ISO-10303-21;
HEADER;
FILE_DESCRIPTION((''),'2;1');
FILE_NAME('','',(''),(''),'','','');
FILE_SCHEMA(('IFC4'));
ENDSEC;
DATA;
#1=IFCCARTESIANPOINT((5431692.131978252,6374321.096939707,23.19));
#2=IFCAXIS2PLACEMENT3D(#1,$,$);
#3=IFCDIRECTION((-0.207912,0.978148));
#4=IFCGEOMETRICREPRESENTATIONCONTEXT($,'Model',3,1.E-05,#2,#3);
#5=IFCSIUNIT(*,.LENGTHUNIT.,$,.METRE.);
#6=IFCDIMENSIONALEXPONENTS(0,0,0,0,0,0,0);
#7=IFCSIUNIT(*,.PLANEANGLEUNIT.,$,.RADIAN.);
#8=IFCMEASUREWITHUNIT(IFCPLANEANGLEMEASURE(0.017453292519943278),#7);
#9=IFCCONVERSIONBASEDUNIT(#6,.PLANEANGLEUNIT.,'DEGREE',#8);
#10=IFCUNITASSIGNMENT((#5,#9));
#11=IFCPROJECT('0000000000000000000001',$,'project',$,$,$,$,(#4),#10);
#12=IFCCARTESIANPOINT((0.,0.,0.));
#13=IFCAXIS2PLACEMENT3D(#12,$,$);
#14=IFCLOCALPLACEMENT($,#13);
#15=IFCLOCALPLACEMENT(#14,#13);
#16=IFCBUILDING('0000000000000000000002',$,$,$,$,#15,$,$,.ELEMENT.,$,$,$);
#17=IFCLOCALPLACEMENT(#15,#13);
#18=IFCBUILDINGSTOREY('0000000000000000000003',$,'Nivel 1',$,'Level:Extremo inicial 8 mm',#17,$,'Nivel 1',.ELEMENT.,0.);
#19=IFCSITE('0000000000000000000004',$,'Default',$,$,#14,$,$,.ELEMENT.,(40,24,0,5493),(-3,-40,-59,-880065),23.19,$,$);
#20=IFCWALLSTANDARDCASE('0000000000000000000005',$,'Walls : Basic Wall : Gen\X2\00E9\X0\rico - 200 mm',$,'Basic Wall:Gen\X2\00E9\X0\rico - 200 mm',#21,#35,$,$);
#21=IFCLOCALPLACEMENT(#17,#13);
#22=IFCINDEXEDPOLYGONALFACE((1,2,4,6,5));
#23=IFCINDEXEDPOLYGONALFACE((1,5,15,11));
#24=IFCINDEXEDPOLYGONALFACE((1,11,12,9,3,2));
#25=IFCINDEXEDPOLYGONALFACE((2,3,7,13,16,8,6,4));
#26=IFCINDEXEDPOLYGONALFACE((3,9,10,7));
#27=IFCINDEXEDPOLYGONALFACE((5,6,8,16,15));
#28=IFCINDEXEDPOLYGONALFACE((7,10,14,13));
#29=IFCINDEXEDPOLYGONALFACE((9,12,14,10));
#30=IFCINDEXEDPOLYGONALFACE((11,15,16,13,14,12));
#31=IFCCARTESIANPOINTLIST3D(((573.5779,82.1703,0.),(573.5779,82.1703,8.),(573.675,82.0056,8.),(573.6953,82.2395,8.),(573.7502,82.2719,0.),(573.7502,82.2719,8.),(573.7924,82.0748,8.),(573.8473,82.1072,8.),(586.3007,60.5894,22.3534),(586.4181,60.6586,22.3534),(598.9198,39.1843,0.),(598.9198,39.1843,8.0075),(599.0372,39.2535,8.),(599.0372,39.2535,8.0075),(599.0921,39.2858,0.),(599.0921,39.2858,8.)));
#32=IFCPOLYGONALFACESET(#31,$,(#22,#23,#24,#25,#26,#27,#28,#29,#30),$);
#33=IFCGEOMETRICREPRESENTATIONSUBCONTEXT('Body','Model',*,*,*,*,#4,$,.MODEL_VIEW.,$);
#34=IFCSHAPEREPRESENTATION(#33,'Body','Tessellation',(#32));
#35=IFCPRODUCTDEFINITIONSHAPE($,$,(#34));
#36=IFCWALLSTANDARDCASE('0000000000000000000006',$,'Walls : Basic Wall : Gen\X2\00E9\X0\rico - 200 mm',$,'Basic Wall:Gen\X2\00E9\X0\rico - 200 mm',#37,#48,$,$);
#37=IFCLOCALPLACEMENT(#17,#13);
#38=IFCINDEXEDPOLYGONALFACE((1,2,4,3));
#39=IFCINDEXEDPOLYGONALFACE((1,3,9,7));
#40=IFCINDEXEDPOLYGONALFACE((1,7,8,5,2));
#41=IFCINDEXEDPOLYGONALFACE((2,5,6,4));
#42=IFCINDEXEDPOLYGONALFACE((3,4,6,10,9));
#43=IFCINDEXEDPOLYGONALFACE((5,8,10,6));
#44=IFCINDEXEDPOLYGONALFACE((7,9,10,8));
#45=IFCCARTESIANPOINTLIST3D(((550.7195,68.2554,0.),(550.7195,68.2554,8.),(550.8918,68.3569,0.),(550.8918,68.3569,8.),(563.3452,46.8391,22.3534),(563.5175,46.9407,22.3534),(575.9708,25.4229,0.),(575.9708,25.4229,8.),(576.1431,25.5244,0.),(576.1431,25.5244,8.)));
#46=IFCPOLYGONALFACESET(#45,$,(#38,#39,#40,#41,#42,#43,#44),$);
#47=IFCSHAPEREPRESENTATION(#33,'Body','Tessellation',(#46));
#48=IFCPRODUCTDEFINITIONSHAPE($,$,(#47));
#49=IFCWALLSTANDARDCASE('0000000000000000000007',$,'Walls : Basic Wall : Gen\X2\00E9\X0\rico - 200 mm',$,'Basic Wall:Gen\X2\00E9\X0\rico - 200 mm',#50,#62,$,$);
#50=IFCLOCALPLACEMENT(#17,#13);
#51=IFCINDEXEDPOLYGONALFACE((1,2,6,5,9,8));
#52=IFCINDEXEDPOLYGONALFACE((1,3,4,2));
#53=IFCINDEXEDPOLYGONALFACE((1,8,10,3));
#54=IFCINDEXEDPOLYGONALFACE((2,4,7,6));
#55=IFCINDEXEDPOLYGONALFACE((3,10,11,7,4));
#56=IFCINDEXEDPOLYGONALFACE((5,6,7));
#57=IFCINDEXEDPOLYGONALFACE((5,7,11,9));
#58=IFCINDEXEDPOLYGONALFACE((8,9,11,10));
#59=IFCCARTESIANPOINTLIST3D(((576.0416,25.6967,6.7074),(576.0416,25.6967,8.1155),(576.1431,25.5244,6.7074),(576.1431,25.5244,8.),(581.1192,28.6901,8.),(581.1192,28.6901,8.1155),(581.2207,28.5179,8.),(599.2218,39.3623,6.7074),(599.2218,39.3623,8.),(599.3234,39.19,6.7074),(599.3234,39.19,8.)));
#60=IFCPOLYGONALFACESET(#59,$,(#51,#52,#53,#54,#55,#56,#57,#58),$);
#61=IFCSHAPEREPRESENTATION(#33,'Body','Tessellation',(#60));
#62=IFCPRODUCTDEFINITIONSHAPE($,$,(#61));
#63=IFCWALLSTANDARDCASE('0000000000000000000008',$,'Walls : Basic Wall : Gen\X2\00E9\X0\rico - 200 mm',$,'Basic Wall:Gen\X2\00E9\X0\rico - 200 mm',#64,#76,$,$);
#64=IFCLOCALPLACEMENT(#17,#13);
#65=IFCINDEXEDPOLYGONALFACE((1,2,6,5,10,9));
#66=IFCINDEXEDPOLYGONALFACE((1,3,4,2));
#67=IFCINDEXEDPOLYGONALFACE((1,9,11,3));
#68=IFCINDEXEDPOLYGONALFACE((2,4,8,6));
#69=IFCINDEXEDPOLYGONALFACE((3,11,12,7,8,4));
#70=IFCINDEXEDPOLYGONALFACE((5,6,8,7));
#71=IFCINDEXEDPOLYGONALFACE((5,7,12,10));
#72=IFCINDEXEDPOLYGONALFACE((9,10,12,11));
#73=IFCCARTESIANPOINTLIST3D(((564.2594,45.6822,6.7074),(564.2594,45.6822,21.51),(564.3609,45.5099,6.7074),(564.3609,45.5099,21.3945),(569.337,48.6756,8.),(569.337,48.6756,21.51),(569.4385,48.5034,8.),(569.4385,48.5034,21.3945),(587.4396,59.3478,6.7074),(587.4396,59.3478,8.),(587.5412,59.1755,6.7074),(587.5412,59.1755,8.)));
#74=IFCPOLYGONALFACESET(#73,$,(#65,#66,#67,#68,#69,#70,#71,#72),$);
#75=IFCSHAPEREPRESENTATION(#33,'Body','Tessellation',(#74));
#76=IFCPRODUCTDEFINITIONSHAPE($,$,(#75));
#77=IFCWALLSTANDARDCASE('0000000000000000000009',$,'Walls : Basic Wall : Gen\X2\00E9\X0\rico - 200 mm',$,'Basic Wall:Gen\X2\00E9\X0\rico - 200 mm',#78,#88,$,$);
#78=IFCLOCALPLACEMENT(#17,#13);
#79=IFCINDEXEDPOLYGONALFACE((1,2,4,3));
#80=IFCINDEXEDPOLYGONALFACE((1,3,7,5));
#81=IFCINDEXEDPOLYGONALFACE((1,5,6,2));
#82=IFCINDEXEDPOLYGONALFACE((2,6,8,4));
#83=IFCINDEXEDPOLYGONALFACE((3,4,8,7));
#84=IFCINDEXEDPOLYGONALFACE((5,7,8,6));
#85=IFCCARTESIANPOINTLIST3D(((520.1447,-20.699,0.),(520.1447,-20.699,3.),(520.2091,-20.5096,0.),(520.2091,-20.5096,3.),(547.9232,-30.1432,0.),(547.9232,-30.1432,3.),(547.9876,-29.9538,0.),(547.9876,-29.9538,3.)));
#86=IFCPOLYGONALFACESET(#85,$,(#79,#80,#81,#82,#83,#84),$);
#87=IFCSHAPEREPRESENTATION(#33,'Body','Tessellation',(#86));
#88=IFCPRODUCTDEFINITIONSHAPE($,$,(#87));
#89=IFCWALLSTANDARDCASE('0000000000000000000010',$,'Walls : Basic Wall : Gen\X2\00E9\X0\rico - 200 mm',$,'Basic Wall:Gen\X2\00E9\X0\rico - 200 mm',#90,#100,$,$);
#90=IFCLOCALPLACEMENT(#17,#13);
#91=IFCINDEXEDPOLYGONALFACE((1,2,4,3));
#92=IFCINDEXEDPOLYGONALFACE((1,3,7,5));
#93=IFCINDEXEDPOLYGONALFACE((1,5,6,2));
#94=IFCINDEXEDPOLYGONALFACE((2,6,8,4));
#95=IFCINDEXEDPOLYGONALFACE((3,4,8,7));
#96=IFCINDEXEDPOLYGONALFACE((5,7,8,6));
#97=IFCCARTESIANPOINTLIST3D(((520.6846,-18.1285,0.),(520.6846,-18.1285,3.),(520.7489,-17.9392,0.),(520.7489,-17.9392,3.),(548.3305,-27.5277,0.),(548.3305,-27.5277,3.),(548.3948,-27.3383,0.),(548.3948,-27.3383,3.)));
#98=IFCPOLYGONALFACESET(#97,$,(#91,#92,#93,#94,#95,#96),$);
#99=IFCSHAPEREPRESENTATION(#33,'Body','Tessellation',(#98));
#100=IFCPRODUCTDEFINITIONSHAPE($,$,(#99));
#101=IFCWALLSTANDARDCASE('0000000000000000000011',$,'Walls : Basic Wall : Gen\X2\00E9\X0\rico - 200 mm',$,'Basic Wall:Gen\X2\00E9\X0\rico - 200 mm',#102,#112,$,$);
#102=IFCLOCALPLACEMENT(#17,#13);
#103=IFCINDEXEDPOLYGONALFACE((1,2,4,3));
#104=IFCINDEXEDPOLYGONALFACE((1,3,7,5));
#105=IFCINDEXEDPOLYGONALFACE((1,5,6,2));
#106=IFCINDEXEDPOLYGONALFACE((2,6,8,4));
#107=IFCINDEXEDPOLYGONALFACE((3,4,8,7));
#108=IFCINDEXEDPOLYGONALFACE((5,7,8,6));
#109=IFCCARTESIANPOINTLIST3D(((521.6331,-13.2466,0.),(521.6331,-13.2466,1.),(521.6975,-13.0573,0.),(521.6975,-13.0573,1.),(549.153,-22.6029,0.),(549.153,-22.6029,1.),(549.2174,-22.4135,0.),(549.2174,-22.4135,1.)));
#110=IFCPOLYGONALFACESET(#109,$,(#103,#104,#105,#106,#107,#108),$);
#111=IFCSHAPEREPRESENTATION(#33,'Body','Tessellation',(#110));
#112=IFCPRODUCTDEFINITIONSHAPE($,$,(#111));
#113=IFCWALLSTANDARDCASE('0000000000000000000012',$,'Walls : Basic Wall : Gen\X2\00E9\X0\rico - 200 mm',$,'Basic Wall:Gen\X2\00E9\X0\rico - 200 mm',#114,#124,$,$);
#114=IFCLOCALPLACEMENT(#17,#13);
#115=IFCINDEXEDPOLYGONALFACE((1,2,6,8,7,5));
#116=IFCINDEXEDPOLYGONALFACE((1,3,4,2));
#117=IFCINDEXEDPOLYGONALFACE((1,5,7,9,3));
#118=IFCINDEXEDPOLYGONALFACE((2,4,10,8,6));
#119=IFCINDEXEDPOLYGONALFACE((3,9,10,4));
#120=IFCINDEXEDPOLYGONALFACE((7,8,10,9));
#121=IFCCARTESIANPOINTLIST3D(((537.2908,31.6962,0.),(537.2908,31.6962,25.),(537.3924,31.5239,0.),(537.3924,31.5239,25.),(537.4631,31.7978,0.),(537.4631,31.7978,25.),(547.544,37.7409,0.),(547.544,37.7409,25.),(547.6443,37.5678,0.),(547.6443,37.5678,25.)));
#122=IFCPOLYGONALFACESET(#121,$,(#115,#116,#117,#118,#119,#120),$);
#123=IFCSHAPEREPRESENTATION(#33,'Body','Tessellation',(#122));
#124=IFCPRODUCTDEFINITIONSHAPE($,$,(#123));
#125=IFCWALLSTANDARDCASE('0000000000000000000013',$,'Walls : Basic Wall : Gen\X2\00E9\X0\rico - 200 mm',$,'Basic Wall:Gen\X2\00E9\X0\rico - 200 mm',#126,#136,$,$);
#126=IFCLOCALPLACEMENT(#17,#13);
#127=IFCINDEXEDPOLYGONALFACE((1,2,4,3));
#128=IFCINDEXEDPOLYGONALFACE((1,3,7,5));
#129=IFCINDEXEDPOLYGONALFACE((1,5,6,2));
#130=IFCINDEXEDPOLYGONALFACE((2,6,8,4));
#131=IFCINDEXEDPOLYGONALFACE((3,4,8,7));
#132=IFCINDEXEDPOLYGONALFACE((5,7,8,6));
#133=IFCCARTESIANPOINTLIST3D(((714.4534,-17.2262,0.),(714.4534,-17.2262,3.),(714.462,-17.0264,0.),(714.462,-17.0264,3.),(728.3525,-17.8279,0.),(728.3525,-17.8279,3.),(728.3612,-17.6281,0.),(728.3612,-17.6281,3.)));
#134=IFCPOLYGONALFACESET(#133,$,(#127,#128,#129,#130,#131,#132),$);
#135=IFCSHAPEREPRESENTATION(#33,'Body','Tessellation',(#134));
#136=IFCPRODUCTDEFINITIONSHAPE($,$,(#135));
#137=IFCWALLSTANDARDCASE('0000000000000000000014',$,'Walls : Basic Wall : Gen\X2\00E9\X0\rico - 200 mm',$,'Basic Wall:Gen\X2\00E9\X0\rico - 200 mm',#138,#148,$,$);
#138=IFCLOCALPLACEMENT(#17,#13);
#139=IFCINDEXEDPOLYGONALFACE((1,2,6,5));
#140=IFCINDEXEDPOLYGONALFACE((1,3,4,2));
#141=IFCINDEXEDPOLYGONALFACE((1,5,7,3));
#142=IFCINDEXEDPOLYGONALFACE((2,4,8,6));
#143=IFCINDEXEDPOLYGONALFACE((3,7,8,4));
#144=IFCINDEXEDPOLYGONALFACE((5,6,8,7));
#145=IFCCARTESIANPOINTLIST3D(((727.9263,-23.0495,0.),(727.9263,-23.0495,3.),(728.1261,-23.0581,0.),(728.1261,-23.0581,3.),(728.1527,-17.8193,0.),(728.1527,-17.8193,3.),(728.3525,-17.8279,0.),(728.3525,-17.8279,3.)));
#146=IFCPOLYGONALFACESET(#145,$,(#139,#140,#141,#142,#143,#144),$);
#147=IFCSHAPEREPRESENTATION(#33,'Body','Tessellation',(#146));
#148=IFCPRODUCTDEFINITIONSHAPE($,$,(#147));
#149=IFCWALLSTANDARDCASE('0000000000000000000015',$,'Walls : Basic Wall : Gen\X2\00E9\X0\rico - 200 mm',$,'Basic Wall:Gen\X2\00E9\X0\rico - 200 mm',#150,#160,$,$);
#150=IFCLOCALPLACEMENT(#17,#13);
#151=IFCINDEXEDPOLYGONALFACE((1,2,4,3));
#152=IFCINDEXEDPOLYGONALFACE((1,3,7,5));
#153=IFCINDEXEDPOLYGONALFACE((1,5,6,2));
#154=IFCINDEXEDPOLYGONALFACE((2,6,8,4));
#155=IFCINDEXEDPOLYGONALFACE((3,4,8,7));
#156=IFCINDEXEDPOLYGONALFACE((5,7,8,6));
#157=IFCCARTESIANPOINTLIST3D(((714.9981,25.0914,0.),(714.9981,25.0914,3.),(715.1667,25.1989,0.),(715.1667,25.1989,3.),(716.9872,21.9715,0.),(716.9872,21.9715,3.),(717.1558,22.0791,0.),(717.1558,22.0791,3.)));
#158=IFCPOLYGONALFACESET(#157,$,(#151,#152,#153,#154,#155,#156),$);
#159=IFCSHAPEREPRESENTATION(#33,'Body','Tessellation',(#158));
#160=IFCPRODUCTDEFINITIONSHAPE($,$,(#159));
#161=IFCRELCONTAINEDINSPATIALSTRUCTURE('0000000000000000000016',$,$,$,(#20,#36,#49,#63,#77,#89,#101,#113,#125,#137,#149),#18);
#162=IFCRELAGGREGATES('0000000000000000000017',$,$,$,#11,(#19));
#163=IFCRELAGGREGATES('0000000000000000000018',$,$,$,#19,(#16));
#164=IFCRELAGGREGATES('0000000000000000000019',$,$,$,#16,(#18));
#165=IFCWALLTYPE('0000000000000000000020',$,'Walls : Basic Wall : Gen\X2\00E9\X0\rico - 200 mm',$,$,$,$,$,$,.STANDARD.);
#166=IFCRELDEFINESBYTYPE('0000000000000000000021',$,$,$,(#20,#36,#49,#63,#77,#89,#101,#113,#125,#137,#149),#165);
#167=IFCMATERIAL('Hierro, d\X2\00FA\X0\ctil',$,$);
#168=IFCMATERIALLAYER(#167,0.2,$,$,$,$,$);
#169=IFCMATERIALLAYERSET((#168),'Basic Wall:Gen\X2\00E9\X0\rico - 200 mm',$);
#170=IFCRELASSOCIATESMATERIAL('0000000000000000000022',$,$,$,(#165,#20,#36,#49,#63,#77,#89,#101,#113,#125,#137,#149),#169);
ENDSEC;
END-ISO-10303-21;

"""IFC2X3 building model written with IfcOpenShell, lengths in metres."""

from ifc_helpers import new_model, entity, si_unit, converted_unit, direction, frame, frame_2d, origin, place, context, subcontext, project, spatial, polyline, rectangle, outline, extrude, clip, bounded_halfspace, material, layer, layer_set, layer_usage, type_object, element, save


model = new_model("IFC2X3")

# Units and contexts
model_context = context("Model", 3, precision=1e-05, world=frame((5431692.131978252, 6374321.096939707, 23.19)), true_north=direction((-0.207912, 0.978148)))
body_context = subcontext(model_context, "Body", "Model", "MODEL_VIEW")
ifc_project = project(units=[si_unit("LENGTHUNIT", "METRE"), converted_unit("PLANEANGLEUNIT", "DEGREE", entity("IfcPlaneAngleMeasure", 0.017453292519943278), si_unit("PLANEANGLEUNIT", "RADIAN"), dimensions=[0, 0, 0, 0, 0, 0, 0])], contexts=[model_context])

# Site, building, storey
site_placement = place(None, origin())
site = spatial("IfcSite", under=ifc_project, at=site_placement, Name="Default", CompositionType="ELEMENT", RefLatitude=(40, 24, 0, 5493), RefLongitude=(-3, -40, -59, -880065), RefElevation=23.19)
building_placement = place(site_placement, origin())
building = spatial("IfcBuilding", under=site, at=building_placement, CompositionType="ELEMENT")
storey_placement = place(building_placement, origin())
storey = spatial("IfcBuildingStorey", under=building, at=storey_placement, Name="Nivel 1", ObjectType="Level:Extremo inicial 8 mm", LongName="Nivel 1", CompositionType="ELEMENT", Elevation=0.0)

# Walls
ifc_material_1 = material(Name="Hierro, dúctil")
ifc_layer_1 = layer(ifc_material_1, 0.2)
ifc_layer_set_1 = layer_set([ifc_layer_1], Name="Basic Wall:Genérico - 200 mm")
wall_type = type_object("IfcWallType", Name="Walls : Basic Wall : Genérico - 200 mm", PredefinedType="STANDARD", material=ifc_layer_set_1)
ifc_layer_usage_1 = layer_usage(ifc_layer_set_1, "AXIS2", "NEGATIVE", 0.1)
wall_1_placement = place(storey_placement, frame((573.6641, 82.2211, 0.0), z_axis=(0.0, 0.0, 1.0), x_axis=(0.507853, -0.861444, 0.0)))
element("IfcWallStandardCase", 1, at=wall_1_placement, inside=storey, type_object=wall_type, material=ifc_layer_usage_1, Name="Walls : Basic Wall : Genérico - 200 mm", ObjectType="Basic Wall:Genérico - 200 mm", context=body_context, shape_type="Clipping", body=[
    clip(clip(clip(clip(clip(extrude(rectangle(XDim=49.9, YDim=0.2, at=frame_2d((24.95, 0.0), x_axis=(-1.0, 0.0))), origin(), (0.0, 0.0, 1.0), 22.3534), bounded_halfspace(frame((0.1912, -0.1, 8.0), z_axis=(-0.5, 0.0, 0.866025), x_axis=(0.0, -1.0, 0.0)), False, frame((0.1912, -0.1, 8.0)), polyline([(0.0, 0.0), (24.8609, 0.0), (24.8609, 0.1363), (0.0, 0.1363), (0.0, 0.0)]))), bounded_halfspace(frame((25.052, -0.1, 22.3534), z_axis=(0.5, 0.0, 0.866025), x_axis=(0.0, 1.0, 0.0)), False, frame((25.052, -0.1, 22.3534)), polyline([(0.0, 0.0), (24.848, 0.0), (24.848, 0.1363), (0.0, 0.1363), (0.0, 0.0)]))), bounded_halfspace(frame((49.9, 0.0363, 8.0), z_axis=(0.0, 0.0, 1.0), x_axis=(0.0, 1.0, 0.0)), False, frame((49.9, 0.0363, 8.0)), polyline([(0.0, 0.0), (0.0, 0.0637), (-49.7088, 0.0637), (-49.7088, 0.0), (0.0, 0.0)]))), bounded_halfspace(frame((0.0, -0.1, 8.0), z_axis=(0.0, 0.0, 1.0), x_axis=(0.0, 1.0, 0.0)), False, frame((0.0, -0.1, 8.0)), polyline([(0.0, 0.0), (0.1912, 0.0), (0.1912, 0.1363), (0.0, 0.1363), (0.0, 0.0)]))), bounded_halfspace(frame((0.1912, 0.0363, 8.0), z_axis=(0.0, 0.0, 1.0), x_axis=(0.0, 1.0, 0.0)), False, frame((0.1912, 0.0363, 8.0)), polyline([(0.0, 0.0), (0.0, 0.0637), (-0.1912, 0.0637), (-0.1912, 0.0), (0.0, 0.0)]))),
])
ifc_layer_usage_2 = layer_usage(ifc_layer_set_1, "AXIS2", "NEGATIVE", 0.1)
wall_2_placement = place(storey_placement, frame((550.8057, 68.3061, 0.0), z_axis=(0.0, 0.0, 1.0), x_axis=(0.507853, -0.861444, 0.0)))
element("IfcWallStandardCase", 2, at=wall_2_placement, inside=storey, type_object=wall_type, material=ifc_layer_usage_2, Name="Walls : Basic Wall : Genérico - 200 mm", ObjectType="Basic Wall:Genérico - 200 mm", context=body_context, shape_type="Clipping", body=[
    clip(clip(extrude(rectangle(XDim=49.7218, YDim=0.2, at=frame_2d((24.8609, 0.0), x_axis=(-1.0, 0.0))), origin(), (0.0, 0.0, 1.0), 22.3534), bounded_halfspace(frame((0.0, -0.1, 8.0), z_axis=(-0.5, 0.0, 0.866025), x_axis=(0.0, -1.0, 0.0)), False, frame((0.0, -0.1, 8.0)), polyline([(0.0, 0.0), (24.8609, 0.0), (24.8609, 0.2), (0.2, 0.2), (0.0, 0.2), (0.0, 0.0)]))), bounded_halfspace(frame((24.8609, -0.1, 22.3534), z_axis=(0.5, 0.0, 0.866025), x_axis=(0.0, 1.0, 0.0)), False, frame((24.8609, -0.1, 22.3534)), polyline([(0.0, 0.0), (24.8609, 0.0), (24.8609, 0.2), (24.6609, 0.2), (1.6609, 0.2), (1.4609, 0.2), (0.0, 0.2), (0.0, 0.0)]))),
])
ifc_layer_usage_3 = layer_usage(ifc_layer_set_1, "AXIS2", "NEGATIVE", 0.1)
wall_3_placement = place(storey_placement, frame((576.0924, 25.6106, 6.7074), z_axis=(0.0, 0.0, 1.0), x_axis=(0.861444, 0.507853, 0.0)))
element("IfcWallStandardCase", 3, at=wall_3_placement, inside=storey, type_object=wall_type, material=ifc_layer_usage_3, Name="Walls : Basic Wall : Genérico - 200 mm", ObjectType="Basic Wall:Genérico - 200 mm", context=body_context, shape_type="Clipping", body=[
    clip(clip(extrude(rectangle(XDim=26.9086, YDim=0.2, at=frame_2d((13.4543, 0.0), x_axis=(-1.0, 0.0))), origin(), (0.0, 0.0, 1.0), 1.408), bounded_halfspace(frame((0.0, -0.1, 1.2926), z_axis=(0.0, -0.5, 0.866025), x_axis=(1.0, 0.0, 0.0)), False, frame((0.0, -0.1, 1.2926)), polyline([(0.0, 0.0), (5.8943, 0.0), (5.8943, 0.2), (0.0, 0.2), (0.0, 0.0)]))), bounded_halfspace(frame((5.8943, -0.1, 1.2926), z_axis=(0.0, 0.0, 1.0), x_axis=(0.0, 1.0, 0.0)), False, frame((5.8943, -0.1, 1.2926)), polyline([(0.0, 0.0), (21.0143, 0.0), (21.0143, 0.2), (20.8637, 0.2), (20.8, 0.2), (0.0, 0.2), (0.0, 0.0)]))),
])
ifc_layer_usage_4 = layer_usage(ifc_layer_set_1, "AXIS2", "NEGATIVE", 0.1)
wall_4_placement = place(storey_placement, frame((564.3102, 45.5961, 6.7074), z_axis=(0.0, 0.0, 1.0), x_axis=(0.861444, 0.507853, 0.0)))
element("IfcWallStandardCase", 4, at=wall_4_placement, inside=storey, type_object=wall_type, material=ifc_layer_usage_4, Name="Walls : Basic Wall : Genérico - 200 mm", ObjectType="Basic Wall:Genérico - 200 mm", context=body_context, shape_type="Clipping", body=[
    clip(clip(extrude(rectangle(XDim=26.9086, YDim=0.2, at=frame_2d((13.4543, 0.0), x_axis=(-1.0, 0.0))), origin(), (0.0, 0.0, 1.0), 14.8026), bounded_halfspace(frame((0.0, -0.1, 14.6871), z_axis=(0.0, -0.5, 0.866025), x_axis=(1.0, 0.0, 0.0)), False, frame((0.0, -0.1, 14.6871)), polyline([(0.0, 0.0), (5.8943, 0.0), (5.8943, 0.2), (0.0, 0.2), (0.0, 0.0)]))), bounded_halfspace(frame((5.8943, -0.1, 1.2926), z_axis=(0.0, 0.0, 1.0), x_axis=(0.0, 1.0, 0.0)), False, frame((5.8943, -0.1, 1.2926)), polyline([(0.0, 0.0), (21.0143, 0.0), (21.0143, 0.2), (0.0, 0.2), (0.0, 0.0)]))),
])
ifc_layer_usage_5 = layer_usage(ifc_layer_set_1, "AXIS2", "NEGATIVE", 0.1)
wall_5_placement = place(storey_placement, frame((547.9554, -30.0485, 0.0), z_axis=(0.0, 0.0, 1.0), x_axis=(-0.946778, 0.321888, 0.0)))
element("IfcWallStandardCase", 5, at=wall_5_placement, inside=storey, type_object=wall_type, material=ifc_layer_usage_5, Name="Walls : Basic Wall : Genérico - 200 mm", ObjectType="Basic Wall:Genérico - 200 mm", context=body_context, shape_type="SweptSolid", body=[
    extrude(rectangle(XDim=29.34, YDim=0.2, at=frame_2d((14.67, 0.0), x_axis=(-1.0, 0.0))), origin(), (0.0, 0.0, 1.0), 3.0),
])
ifc_layer_usage_6 = layer_usage(ifc_layer_set_1, "AXIS2", "NEGATIVE", 0.1)
wall_6_placement = place(storey_placement, frame((548.3627, -27.433, 0.0), z_axis=(0.0, 0.0, 1.0), x_axis=(-0.946778, 0.321888, 0.0)))
element("IfcWallStandardCase", 6, at=wall_6_placement, inside=storey, type_object=wall_type, material=ifc_layer_usage_6, Name="Walls : Basic Wall : Genérico - 200 mm", ObjectType="Basic Wall:Genérico - 200 mm", context=body_context, shape_type="SweptSolid", body=[
    extrude(rectangle(XDim=29.2, YDim=0.2, at=frame_2d((14.6, 0.0), x_axis=(-1.0, 0.0))), origin(), (0.0, 0.0, 1.0), 3.0),
])
ifc_layer_usage_7 = layer_usage(ifc_layer_set_1, "AXIS2", "NEGATIVE", 0.1)
wall_7_placement = place(storey_placement, frame((549.1852, -22.5082, 0.0), z_axis=(0.0, 0.0, 1.0), x_axis=(-0.946778, 0.321888, 0.0)))
element("IfcWallStandardCase", 7, at=wall_7_placement, inside=storey, type_object=wall_type, material=ifc_layer_usage_7, Name="Walls : Basic Wall : Genérico - 200 mm", ObjectType="Basic Wall:Genérico - 200 mm", context=body_context, shape_type="SweptSolid", body=[
    extrude(rectangle(XDim=29.0668, YDim=0.2, at=frame_2d((14.5334, 0.0), x_axis=(-1.0, 0.0))), origin(), (0.0, 0.0, 1.0), 1.0),
])
ifc_layer_usage_8 = layer_usage(ifc_layer_set_1, "AXIS2", "NEGATIVE", 0.1)
wall_8_placement = place(storey_placement, frame((547.5948, 37.6547, 0.0), z_axis=(0.0, 0.0, 1.0), x_axis=(-0.861444, -0.507853, 0.0)))
element("IfcWallStandardCase", 8, at=wall_8_placement, inside=storey, type_object=wall_type, material=ifc_layer_usage_8, Name="Walls : Basic Wall : Genérico - 200 mm", ObjectType="Basic Wall:Genérico - 200 mm", context=body_context, shape_type="SweptSolid", body=[
    extrude(outline(polyline([(11.9024, -0.1), (11.9024, 0.1), (0.0015, 0.1), (0.0, -0.1), (11.7024, -0.1), (11.9024, -0.1)])), origin(), (0.0, 0.0, 1.0), 25.0),
])
ifc_layer_usage_9 = layer_usage(ifc_layer_set_1, "AXIS2", "NEGATIVE", 0.1)
wall_9_placement = place(storey_placement, frame((714.4577, -17.1263, 0.0), z_axis=(0.0, 0.0, 1.0), x_axis=(0.999064, -0.043255, 0.0)))
element("IfcWallStandardCase", 9, at=wall_9_placement, inside=storey, type_object=wall_type, material=ifc_layer_usage_9, Name="Walls : Basic Wall : Genérico - 200 mm", ObjectType="Basic Wall:Genérico - 200 mm", context=body_context, shape_type="SweptSolid", body=[
    extrude(rectangle(XDim=13.9122, YDim=0.2, at=frame_2d((6.9561, 0.0), x_axis=(-1.0, 0.0))), origin(), (0.0, 0.0, 1.0), 3.0),
])
ifc_layer_usage_10 = layer_usage(ifc_layer_set_1, "AXIS2", "NEGATIVE", 0.1)
wall_10_placement = place(storey_placement, frame((728.2526, -17.8236, 0.0), z_axis=(0.0, 0.0, 1.0), x_axis=(-0.043255, -0.999064, 0.0)))
element("IfcWallStandardCase", 10, at=wall_10_placement, inside=storey, type_object=wall_type, material=ifc_layer_usage_10, Name="Walls : Basic Wall : Genérico - 200 mm", ObjectType="Basic Wall:Genérico - 200 mm", context=body_context, shape_type="SweptSolid", body=[
    extrude(rectangle(XDim=5.2351, YDim=0.2, at=frame_2d((2.6175, 0.0), x_axis=(-1.0, 0.0))), origin(), (0.0, 0.0, 1.0), 3.0),
])
ifc_layer_usage_11 = layer_usage(ifc_layer_set_1, "AXIS2", "NEGATIVE", 0.1)
wall_11_placement = place(storey_placement, frame((717.0715, 22.0253, 0.0), z_axis=(0.0, 0.0, 1.0), x_axis=(-0.537608, 0.843195, 0.0)))
element("IfcWallStandardCase", 11, at=wall_11_placement, inside=storey, type_object=wall_type, material=ifc_layer_usage_11, Name="Walls : Basic Wall : Genérico - 200 mm", ObjectType="Basic Wall:Genérico - 200 mm", context=body_context, shape_type="SweptSolid", body=[
    extrude(rectangle(XDim=3.7, YDim=0.2, at=frame_2d((1.85, 0.0), x_axis=(-1.0, 0.0))), origin(), (0.0, 0.0, 1.0), 3.0),
])

save(model, "model.ifc")
